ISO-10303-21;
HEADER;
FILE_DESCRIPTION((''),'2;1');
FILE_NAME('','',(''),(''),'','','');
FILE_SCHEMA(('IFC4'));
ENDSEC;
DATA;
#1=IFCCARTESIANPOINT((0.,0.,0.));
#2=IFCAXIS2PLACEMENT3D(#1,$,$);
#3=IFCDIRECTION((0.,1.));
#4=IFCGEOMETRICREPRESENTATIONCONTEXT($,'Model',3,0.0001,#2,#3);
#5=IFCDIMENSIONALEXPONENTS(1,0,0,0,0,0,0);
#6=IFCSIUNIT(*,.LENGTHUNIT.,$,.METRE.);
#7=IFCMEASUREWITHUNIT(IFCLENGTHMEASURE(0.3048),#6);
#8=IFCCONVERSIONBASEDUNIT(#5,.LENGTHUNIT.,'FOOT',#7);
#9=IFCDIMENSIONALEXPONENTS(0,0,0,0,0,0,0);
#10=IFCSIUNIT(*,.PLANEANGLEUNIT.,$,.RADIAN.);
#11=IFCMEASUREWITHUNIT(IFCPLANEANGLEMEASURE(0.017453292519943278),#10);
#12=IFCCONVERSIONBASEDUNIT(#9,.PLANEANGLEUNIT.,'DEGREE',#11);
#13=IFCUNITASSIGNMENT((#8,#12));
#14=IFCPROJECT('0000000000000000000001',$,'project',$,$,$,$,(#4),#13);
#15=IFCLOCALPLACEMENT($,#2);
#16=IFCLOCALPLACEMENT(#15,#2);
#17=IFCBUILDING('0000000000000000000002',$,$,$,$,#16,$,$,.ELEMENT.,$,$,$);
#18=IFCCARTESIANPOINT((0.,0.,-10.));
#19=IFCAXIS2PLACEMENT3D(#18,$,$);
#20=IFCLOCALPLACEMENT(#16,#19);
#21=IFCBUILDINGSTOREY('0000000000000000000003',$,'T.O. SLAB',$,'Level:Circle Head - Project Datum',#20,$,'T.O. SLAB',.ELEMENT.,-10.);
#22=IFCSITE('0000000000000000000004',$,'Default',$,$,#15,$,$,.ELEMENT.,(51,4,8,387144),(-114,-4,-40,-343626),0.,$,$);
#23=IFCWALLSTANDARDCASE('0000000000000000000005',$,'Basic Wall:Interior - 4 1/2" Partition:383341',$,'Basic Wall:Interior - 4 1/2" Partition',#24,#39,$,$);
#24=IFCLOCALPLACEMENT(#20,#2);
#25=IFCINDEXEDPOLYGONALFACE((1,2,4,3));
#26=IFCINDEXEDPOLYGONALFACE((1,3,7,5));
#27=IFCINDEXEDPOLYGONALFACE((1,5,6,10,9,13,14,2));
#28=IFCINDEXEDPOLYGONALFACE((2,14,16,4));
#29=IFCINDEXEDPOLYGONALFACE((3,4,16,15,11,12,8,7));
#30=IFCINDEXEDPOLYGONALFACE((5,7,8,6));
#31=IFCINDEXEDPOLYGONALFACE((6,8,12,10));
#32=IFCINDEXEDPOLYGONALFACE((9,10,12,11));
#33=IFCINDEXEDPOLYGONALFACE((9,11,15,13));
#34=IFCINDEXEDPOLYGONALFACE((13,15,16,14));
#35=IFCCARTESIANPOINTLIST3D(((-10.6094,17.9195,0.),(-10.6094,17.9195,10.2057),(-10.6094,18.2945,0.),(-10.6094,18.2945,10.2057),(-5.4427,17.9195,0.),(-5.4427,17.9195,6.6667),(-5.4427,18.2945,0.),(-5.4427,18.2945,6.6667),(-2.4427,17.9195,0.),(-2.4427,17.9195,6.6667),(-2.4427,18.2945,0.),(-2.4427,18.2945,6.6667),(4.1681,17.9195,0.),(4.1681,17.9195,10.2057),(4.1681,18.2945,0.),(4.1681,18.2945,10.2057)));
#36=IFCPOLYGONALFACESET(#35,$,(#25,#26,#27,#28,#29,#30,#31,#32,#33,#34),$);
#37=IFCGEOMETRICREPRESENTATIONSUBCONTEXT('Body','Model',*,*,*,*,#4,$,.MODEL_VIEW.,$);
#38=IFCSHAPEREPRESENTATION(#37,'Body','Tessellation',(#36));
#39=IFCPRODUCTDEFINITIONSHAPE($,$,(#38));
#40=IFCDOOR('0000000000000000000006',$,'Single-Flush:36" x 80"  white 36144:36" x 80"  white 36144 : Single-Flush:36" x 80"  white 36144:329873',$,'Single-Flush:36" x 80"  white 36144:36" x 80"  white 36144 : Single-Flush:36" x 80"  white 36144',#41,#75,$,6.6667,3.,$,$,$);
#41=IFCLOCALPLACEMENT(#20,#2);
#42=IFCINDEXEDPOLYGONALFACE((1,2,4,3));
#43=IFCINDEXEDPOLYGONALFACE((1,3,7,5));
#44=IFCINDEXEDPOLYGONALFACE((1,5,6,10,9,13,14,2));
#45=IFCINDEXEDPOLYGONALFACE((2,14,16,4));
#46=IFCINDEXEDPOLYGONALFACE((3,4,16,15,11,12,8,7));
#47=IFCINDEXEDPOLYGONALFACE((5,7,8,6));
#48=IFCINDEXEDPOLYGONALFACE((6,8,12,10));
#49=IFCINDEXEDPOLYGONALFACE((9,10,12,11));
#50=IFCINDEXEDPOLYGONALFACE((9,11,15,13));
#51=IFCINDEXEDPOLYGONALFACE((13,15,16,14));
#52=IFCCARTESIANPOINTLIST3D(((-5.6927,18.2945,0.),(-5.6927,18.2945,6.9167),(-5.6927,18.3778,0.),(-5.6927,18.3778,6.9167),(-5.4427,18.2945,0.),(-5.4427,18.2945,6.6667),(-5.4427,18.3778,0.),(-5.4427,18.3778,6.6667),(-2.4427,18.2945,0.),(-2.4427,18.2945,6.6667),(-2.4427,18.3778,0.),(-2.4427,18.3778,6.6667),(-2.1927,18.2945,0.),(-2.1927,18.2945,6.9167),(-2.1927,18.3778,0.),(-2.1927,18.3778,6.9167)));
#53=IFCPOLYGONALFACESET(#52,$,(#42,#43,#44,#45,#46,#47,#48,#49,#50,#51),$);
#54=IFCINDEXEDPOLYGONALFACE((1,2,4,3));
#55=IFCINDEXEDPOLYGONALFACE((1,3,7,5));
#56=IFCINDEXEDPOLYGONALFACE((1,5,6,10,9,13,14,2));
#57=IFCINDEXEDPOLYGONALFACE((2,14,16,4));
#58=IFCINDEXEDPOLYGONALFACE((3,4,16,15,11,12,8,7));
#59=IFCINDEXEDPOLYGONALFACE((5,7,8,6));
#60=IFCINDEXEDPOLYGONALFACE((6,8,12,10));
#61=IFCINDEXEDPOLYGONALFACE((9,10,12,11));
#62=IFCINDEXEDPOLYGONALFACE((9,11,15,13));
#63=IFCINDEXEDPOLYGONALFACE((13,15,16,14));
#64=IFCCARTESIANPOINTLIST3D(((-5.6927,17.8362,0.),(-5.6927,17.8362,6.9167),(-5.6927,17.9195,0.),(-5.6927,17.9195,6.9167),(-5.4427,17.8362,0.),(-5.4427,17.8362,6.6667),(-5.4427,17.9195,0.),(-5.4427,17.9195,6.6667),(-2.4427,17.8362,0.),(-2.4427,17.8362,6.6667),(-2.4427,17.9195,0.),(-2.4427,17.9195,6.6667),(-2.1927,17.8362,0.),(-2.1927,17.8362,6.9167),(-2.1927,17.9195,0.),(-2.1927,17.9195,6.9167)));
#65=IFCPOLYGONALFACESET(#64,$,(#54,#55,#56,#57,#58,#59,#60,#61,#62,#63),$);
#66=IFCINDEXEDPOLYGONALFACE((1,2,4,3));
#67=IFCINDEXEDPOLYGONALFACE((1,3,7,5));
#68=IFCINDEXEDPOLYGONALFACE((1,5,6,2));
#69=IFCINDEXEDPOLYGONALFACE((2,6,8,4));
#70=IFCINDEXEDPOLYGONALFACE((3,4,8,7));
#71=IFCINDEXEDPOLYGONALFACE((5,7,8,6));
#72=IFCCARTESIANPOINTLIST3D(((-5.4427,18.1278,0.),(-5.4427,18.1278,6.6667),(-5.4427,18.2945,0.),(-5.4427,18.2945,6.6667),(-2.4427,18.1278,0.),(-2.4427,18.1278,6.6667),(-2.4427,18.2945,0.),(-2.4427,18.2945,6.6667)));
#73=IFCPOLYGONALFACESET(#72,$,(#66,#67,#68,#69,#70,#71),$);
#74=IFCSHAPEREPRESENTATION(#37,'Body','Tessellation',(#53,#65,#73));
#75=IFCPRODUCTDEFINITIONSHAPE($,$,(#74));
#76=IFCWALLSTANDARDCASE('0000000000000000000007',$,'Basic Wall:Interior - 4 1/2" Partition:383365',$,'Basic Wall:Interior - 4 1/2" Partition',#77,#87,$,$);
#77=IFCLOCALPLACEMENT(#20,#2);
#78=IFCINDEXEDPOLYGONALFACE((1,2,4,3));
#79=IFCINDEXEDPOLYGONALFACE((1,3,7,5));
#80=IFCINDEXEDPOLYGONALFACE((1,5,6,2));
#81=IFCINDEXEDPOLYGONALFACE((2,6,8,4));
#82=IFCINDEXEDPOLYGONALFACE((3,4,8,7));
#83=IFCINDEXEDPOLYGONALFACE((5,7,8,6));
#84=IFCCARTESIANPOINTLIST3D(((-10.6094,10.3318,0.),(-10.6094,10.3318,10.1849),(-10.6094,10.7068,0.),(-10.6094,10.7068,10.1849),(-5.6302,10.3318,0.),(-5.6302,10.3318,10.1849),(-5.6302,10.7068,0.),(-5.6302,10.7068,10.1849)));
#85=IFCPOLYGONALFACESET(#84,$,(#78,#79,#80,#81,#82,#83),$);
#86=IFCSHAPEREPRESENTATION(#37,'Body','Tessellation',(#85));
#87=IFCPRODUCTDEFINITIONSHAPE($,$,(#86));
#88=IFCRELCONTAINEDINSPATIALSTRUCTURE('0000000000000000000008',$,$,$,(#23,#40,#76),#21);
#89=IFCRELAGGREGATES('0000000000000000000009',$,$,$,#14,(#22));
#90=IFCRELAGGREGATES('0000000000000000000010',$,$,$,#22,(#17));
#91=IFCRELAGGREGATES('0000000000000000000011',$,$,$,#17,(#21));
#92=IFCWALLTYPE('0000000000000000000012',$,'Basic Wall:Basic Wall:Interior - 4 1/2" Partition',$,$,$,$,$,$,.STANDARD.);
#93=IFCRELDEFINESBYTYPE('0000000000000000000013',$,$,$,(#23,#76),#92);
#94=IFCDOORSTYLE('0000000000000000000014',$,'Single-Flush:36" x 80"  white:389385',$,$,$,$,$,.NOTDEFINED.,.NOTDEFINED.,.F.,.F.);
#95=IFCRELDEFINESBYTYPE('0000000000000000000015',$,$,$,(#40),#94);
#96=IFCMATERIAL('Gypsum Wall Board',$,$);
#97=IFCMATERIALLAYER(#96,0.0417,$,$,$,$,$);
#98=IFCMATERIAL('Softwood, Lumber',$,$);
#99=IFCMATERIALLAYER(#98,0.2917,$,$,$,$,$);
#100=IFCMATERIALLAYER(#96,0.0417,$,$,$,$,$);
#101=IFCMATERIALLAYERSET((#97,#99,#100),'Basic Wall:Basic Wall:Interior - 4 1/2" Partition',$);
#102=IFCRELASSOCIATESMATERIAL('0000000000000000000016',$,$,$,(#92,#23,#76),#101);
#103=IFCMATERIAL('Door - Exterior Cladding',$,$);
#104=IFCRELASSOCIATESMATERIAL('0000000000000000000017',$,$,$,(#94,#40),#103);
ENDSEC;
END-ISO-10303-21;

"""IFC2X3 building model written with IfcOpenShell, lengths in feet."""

from ifc_helpers import new_model, entity, si_unit, converted_unit, direction, frame, frame_2d, origin, place, context, subcontext, project, spatial, polyline, rectangle, outline, extrude, source, transform, mapped, material, layer, layer_set, layer_usage, type_object, type_shapes, element, fill, save


model = new_model("IFC2X3")

# Units and contexts
model_context = context("Model", 3, precision=0.0001, world=origin(), true_north=direction((0.0, 1.0)))
body_context = subcontext(model_context, "Body", "Model", "MODEL_VIEW")
ifc_project = project(units=[converted_unit("LENGTHUNIT", "FOOT", entity("IfcLengthMeasure", 0.3048), si_unit("LENGTHUNIT", "METRE"), dimensions=[1, 0, 0, 0, 0, 0, 0]), converted_unit("PLANEANGLEUNIT", "DEGREE", entity("IfcPlaneAngleMeasure", 0.017453292519943278), si_unit("PLANEANGLEUNIT", "RADIAN"), dimensions=[0, 0, 0, 0, 0, 0, 0])], contexts=[model_context])

# Site, building, storey
site_placement = place(None, origin())
site = spatial("IfcSite", under=ifc_project, at=site_placement, Name="Default", CompositionType="ELEMENT", RefLatitude=(51, 4, 8, 387144), RefLongitude=(-114, -4, -40, -343626), RefElevation=0.0)
building_placement = place(site_placement, origin())
building = spatial("IfcBuilding", under=site, at=building_placement, CompositionType="ELEMENT")
storey_placement = place(building_placement, frame((0.0, 0.0, -10.0)))
storey = spatial("IfcBuildingStorey", under=building, at=storey_placement, Name="T.O. SLAB", ObjectType="Level:Circle Head - Project Datum", LongName="T.O. SLAB", CompositionType="ELEMENT", Elevation=-10.0)

# Shared definitions
ifc_material_1 = material(Name="Gypsum Wall Board")
ifc_layer_1 = layer(ifc_material_1, 0.0417)
ifc_material_2 = material(Name="Softwood, Lumber")
ifc_layer_2 = layer(ifc_material_2, 0.2917)
ifc_layer_3 = layer(ifc_material_1, 0.0417)
ifc_layer_set_1 = layer_set([ifc_layer_1, ifc_layer_2, ifc_layer_3], Name="Basic Wall:Basic Wall:Interior - 4 1/2\" Partition")
wall_type_1 = type_object("IfcWallType", Name="Basic Wall:Basic Wall:Interior - 4 1/2\" Partition", PredefinedType="STANDARD", material=ifc_layer_set_1)
ifc_material_3 = material(Name="Door - Exterior Cladding")

# Wall, opening, door
ifc_layer_usage_1 = layer_usage(ifc_layer_set_1, "AXIS2", "NEGATIVE", 0.1875)
wall_1_placement = place(storey_placement, frame((-10.6094, 18.107, 0.0)))
wall_1 = element("IfcWallStandardCase", 1, at=wall_1_placement, inside=storey, type_object=wall_type_1, material=ifc_layer_usage_1, Name="Basic Wall:Interior - 4 1/2\" Partition:383341", ObjectType="Basic Wall:Interior - 4 1/2\" Partition", context=body_context, shape_type="SweptSolid", body=[
    extrude(rectangle(XDim=14.7775, YDim=0.375, at=frame_2d((7.3887, 0.0), x_axis=(-1.0, 0.0))), origin(), (0.0, 0.0, 1.0), 10.2057),
])
opening_1_placement = place(wall_1_placement, frame((10.6094, -18.107, 0.0)))
opening_1 = element("IfcOpeningElement", 2, at=opening_1_placement, cuts=wall_1, ObjectType="Opening", context=body_context, shape_type="SweptSolid", body=[
    extrude(rectangle(XDim=6.6667, YDim=3.0, at=frame_2d((0.0, 0.0), x_axis=(1.0, 0.0))), frame((-3.9427, 17.9158, 3.3333), z_axis=(0.0, 1.0, 0.0), x_axis=(0.0, 0.0, 1.0)), (0.0, 0.0, 1.0), 0.3825),
])
door_style_1 = type_object("IfcDoorStyle", Name="Single-Flush:36\" x 80\"  white:389385", ConstructionType="NOTDEFINED", OperationType="NOTDEFINED", ParameterTakesPrecedence=False, Sizeable=False, material=ifc_material_3)
shared_shape_1 = source(origin(), body_context, "Body", "SweptSolid", [
    extrude(outline(polyline([(-1.75, -3.5208), (1.75, -3.5208), (1.75, 3.3958), (1.5, 3.3958), (1.5, -3.2708), (-1.5, -3.2708), (-1.5, 3.3958), (-1.75, 3.3958), (-1.75, -3.5208)])), frame((1.5, -0.0038, 3.3958), z_axis=(0.0, 1.0, 0.0), x_axis=(1.0, 0.0, 0.0)), (0.0, 0.0, 1.0), 0.0833),
    extrude(outline(polyline([(-3.3958, -1.75), (3.5208, -1.75), (3.5208, 1.75), (-3.3958, 1.75), (-3.3958, 1.5), (3.2708, 1.5), (3.2708, -1.5), (-3.3958, -1.5), (-3.3958, -1.75)])), frame((1.5, -0.4621, 3.3958), z_axis=(0.0, 1.0, 0.0), x_axis=(0.0, 0.0, 1.0)), (0.0, 0.0, 1.0), 0.0833),
    extrude(rectangle(XDim=0.1667, YDim=3.0, at=frame_2d((0.0, 0.0), x_axis=(1.0, 0.0))), frame((1.5, -0.0871, 0.0), z_axis=(0.0, 0.0, 1.0), x_axis=(0.0, 1.0, 0.0)), (0.0, 0.0, 1.0), 6.6667),
])
type_shapes(door_style_1, [shared_shape_1])
door_1_placement = place(opening_1_placement, frame((-5.4427, 18.2983, 0.0)))
door_1 = element("IfcDoor", 3, at=door_1_placement, inside=storey, type_object=door_style_1, material=ifc_material_3, Name="Single-Flush:36\" x 80\"  white 36144:36\" x 80\"  white 36144 : Single-Flush:36\" x 80\"  white 36144:329873", ObjectType="Single-Flush:36\" x 80\"  white 36144:36\" x 80\"  white 36144 : Single-Flush:36\" x 80\"  white 36144", OverallHeight=6.6667, OverallWidth=3.0, context=body_context, shape_type="MappedRepresentation", body=[
    mapped(shared_shape_1, transform((0.0, 0.0, 0.0), scale=1.0)),
])
fill(opening_1, door_1)

# Wall
ifc_layer_usage_2 = layer_usage(ifc_layer_set_1, "AXIS2", "NEGATIVE", 0.1875)
wall_2_placement = place(storey_placement, frame((-5.6302, 10.5193, 0.0), z_axis=(0.0, 0.0, 1.0), x_axis=(-1.0, 0.0, 0.0)))
element("IfcWallStandardCase", 4, at=wall_2_placement, inside=storey, type_object=wall_type_1, material=ifc_layer_usage_2, Name="Basic Wall:Interior - 4 1/2\" Partition:383365", ObjectType="Basic Wall:Interior - 4 1/2\" Partition", context=body_context, shape_type="SweptSolid", body=[
    extrude(rectangle(XDim=4.9792, YDim=0.375, at=frame_2d((2.4896, 0.0), x_axis=(-1.0, 0.0))), origin(), (0.0, 0.0, 1.0), 10.1849),
])

save(model, "model.ifc")
